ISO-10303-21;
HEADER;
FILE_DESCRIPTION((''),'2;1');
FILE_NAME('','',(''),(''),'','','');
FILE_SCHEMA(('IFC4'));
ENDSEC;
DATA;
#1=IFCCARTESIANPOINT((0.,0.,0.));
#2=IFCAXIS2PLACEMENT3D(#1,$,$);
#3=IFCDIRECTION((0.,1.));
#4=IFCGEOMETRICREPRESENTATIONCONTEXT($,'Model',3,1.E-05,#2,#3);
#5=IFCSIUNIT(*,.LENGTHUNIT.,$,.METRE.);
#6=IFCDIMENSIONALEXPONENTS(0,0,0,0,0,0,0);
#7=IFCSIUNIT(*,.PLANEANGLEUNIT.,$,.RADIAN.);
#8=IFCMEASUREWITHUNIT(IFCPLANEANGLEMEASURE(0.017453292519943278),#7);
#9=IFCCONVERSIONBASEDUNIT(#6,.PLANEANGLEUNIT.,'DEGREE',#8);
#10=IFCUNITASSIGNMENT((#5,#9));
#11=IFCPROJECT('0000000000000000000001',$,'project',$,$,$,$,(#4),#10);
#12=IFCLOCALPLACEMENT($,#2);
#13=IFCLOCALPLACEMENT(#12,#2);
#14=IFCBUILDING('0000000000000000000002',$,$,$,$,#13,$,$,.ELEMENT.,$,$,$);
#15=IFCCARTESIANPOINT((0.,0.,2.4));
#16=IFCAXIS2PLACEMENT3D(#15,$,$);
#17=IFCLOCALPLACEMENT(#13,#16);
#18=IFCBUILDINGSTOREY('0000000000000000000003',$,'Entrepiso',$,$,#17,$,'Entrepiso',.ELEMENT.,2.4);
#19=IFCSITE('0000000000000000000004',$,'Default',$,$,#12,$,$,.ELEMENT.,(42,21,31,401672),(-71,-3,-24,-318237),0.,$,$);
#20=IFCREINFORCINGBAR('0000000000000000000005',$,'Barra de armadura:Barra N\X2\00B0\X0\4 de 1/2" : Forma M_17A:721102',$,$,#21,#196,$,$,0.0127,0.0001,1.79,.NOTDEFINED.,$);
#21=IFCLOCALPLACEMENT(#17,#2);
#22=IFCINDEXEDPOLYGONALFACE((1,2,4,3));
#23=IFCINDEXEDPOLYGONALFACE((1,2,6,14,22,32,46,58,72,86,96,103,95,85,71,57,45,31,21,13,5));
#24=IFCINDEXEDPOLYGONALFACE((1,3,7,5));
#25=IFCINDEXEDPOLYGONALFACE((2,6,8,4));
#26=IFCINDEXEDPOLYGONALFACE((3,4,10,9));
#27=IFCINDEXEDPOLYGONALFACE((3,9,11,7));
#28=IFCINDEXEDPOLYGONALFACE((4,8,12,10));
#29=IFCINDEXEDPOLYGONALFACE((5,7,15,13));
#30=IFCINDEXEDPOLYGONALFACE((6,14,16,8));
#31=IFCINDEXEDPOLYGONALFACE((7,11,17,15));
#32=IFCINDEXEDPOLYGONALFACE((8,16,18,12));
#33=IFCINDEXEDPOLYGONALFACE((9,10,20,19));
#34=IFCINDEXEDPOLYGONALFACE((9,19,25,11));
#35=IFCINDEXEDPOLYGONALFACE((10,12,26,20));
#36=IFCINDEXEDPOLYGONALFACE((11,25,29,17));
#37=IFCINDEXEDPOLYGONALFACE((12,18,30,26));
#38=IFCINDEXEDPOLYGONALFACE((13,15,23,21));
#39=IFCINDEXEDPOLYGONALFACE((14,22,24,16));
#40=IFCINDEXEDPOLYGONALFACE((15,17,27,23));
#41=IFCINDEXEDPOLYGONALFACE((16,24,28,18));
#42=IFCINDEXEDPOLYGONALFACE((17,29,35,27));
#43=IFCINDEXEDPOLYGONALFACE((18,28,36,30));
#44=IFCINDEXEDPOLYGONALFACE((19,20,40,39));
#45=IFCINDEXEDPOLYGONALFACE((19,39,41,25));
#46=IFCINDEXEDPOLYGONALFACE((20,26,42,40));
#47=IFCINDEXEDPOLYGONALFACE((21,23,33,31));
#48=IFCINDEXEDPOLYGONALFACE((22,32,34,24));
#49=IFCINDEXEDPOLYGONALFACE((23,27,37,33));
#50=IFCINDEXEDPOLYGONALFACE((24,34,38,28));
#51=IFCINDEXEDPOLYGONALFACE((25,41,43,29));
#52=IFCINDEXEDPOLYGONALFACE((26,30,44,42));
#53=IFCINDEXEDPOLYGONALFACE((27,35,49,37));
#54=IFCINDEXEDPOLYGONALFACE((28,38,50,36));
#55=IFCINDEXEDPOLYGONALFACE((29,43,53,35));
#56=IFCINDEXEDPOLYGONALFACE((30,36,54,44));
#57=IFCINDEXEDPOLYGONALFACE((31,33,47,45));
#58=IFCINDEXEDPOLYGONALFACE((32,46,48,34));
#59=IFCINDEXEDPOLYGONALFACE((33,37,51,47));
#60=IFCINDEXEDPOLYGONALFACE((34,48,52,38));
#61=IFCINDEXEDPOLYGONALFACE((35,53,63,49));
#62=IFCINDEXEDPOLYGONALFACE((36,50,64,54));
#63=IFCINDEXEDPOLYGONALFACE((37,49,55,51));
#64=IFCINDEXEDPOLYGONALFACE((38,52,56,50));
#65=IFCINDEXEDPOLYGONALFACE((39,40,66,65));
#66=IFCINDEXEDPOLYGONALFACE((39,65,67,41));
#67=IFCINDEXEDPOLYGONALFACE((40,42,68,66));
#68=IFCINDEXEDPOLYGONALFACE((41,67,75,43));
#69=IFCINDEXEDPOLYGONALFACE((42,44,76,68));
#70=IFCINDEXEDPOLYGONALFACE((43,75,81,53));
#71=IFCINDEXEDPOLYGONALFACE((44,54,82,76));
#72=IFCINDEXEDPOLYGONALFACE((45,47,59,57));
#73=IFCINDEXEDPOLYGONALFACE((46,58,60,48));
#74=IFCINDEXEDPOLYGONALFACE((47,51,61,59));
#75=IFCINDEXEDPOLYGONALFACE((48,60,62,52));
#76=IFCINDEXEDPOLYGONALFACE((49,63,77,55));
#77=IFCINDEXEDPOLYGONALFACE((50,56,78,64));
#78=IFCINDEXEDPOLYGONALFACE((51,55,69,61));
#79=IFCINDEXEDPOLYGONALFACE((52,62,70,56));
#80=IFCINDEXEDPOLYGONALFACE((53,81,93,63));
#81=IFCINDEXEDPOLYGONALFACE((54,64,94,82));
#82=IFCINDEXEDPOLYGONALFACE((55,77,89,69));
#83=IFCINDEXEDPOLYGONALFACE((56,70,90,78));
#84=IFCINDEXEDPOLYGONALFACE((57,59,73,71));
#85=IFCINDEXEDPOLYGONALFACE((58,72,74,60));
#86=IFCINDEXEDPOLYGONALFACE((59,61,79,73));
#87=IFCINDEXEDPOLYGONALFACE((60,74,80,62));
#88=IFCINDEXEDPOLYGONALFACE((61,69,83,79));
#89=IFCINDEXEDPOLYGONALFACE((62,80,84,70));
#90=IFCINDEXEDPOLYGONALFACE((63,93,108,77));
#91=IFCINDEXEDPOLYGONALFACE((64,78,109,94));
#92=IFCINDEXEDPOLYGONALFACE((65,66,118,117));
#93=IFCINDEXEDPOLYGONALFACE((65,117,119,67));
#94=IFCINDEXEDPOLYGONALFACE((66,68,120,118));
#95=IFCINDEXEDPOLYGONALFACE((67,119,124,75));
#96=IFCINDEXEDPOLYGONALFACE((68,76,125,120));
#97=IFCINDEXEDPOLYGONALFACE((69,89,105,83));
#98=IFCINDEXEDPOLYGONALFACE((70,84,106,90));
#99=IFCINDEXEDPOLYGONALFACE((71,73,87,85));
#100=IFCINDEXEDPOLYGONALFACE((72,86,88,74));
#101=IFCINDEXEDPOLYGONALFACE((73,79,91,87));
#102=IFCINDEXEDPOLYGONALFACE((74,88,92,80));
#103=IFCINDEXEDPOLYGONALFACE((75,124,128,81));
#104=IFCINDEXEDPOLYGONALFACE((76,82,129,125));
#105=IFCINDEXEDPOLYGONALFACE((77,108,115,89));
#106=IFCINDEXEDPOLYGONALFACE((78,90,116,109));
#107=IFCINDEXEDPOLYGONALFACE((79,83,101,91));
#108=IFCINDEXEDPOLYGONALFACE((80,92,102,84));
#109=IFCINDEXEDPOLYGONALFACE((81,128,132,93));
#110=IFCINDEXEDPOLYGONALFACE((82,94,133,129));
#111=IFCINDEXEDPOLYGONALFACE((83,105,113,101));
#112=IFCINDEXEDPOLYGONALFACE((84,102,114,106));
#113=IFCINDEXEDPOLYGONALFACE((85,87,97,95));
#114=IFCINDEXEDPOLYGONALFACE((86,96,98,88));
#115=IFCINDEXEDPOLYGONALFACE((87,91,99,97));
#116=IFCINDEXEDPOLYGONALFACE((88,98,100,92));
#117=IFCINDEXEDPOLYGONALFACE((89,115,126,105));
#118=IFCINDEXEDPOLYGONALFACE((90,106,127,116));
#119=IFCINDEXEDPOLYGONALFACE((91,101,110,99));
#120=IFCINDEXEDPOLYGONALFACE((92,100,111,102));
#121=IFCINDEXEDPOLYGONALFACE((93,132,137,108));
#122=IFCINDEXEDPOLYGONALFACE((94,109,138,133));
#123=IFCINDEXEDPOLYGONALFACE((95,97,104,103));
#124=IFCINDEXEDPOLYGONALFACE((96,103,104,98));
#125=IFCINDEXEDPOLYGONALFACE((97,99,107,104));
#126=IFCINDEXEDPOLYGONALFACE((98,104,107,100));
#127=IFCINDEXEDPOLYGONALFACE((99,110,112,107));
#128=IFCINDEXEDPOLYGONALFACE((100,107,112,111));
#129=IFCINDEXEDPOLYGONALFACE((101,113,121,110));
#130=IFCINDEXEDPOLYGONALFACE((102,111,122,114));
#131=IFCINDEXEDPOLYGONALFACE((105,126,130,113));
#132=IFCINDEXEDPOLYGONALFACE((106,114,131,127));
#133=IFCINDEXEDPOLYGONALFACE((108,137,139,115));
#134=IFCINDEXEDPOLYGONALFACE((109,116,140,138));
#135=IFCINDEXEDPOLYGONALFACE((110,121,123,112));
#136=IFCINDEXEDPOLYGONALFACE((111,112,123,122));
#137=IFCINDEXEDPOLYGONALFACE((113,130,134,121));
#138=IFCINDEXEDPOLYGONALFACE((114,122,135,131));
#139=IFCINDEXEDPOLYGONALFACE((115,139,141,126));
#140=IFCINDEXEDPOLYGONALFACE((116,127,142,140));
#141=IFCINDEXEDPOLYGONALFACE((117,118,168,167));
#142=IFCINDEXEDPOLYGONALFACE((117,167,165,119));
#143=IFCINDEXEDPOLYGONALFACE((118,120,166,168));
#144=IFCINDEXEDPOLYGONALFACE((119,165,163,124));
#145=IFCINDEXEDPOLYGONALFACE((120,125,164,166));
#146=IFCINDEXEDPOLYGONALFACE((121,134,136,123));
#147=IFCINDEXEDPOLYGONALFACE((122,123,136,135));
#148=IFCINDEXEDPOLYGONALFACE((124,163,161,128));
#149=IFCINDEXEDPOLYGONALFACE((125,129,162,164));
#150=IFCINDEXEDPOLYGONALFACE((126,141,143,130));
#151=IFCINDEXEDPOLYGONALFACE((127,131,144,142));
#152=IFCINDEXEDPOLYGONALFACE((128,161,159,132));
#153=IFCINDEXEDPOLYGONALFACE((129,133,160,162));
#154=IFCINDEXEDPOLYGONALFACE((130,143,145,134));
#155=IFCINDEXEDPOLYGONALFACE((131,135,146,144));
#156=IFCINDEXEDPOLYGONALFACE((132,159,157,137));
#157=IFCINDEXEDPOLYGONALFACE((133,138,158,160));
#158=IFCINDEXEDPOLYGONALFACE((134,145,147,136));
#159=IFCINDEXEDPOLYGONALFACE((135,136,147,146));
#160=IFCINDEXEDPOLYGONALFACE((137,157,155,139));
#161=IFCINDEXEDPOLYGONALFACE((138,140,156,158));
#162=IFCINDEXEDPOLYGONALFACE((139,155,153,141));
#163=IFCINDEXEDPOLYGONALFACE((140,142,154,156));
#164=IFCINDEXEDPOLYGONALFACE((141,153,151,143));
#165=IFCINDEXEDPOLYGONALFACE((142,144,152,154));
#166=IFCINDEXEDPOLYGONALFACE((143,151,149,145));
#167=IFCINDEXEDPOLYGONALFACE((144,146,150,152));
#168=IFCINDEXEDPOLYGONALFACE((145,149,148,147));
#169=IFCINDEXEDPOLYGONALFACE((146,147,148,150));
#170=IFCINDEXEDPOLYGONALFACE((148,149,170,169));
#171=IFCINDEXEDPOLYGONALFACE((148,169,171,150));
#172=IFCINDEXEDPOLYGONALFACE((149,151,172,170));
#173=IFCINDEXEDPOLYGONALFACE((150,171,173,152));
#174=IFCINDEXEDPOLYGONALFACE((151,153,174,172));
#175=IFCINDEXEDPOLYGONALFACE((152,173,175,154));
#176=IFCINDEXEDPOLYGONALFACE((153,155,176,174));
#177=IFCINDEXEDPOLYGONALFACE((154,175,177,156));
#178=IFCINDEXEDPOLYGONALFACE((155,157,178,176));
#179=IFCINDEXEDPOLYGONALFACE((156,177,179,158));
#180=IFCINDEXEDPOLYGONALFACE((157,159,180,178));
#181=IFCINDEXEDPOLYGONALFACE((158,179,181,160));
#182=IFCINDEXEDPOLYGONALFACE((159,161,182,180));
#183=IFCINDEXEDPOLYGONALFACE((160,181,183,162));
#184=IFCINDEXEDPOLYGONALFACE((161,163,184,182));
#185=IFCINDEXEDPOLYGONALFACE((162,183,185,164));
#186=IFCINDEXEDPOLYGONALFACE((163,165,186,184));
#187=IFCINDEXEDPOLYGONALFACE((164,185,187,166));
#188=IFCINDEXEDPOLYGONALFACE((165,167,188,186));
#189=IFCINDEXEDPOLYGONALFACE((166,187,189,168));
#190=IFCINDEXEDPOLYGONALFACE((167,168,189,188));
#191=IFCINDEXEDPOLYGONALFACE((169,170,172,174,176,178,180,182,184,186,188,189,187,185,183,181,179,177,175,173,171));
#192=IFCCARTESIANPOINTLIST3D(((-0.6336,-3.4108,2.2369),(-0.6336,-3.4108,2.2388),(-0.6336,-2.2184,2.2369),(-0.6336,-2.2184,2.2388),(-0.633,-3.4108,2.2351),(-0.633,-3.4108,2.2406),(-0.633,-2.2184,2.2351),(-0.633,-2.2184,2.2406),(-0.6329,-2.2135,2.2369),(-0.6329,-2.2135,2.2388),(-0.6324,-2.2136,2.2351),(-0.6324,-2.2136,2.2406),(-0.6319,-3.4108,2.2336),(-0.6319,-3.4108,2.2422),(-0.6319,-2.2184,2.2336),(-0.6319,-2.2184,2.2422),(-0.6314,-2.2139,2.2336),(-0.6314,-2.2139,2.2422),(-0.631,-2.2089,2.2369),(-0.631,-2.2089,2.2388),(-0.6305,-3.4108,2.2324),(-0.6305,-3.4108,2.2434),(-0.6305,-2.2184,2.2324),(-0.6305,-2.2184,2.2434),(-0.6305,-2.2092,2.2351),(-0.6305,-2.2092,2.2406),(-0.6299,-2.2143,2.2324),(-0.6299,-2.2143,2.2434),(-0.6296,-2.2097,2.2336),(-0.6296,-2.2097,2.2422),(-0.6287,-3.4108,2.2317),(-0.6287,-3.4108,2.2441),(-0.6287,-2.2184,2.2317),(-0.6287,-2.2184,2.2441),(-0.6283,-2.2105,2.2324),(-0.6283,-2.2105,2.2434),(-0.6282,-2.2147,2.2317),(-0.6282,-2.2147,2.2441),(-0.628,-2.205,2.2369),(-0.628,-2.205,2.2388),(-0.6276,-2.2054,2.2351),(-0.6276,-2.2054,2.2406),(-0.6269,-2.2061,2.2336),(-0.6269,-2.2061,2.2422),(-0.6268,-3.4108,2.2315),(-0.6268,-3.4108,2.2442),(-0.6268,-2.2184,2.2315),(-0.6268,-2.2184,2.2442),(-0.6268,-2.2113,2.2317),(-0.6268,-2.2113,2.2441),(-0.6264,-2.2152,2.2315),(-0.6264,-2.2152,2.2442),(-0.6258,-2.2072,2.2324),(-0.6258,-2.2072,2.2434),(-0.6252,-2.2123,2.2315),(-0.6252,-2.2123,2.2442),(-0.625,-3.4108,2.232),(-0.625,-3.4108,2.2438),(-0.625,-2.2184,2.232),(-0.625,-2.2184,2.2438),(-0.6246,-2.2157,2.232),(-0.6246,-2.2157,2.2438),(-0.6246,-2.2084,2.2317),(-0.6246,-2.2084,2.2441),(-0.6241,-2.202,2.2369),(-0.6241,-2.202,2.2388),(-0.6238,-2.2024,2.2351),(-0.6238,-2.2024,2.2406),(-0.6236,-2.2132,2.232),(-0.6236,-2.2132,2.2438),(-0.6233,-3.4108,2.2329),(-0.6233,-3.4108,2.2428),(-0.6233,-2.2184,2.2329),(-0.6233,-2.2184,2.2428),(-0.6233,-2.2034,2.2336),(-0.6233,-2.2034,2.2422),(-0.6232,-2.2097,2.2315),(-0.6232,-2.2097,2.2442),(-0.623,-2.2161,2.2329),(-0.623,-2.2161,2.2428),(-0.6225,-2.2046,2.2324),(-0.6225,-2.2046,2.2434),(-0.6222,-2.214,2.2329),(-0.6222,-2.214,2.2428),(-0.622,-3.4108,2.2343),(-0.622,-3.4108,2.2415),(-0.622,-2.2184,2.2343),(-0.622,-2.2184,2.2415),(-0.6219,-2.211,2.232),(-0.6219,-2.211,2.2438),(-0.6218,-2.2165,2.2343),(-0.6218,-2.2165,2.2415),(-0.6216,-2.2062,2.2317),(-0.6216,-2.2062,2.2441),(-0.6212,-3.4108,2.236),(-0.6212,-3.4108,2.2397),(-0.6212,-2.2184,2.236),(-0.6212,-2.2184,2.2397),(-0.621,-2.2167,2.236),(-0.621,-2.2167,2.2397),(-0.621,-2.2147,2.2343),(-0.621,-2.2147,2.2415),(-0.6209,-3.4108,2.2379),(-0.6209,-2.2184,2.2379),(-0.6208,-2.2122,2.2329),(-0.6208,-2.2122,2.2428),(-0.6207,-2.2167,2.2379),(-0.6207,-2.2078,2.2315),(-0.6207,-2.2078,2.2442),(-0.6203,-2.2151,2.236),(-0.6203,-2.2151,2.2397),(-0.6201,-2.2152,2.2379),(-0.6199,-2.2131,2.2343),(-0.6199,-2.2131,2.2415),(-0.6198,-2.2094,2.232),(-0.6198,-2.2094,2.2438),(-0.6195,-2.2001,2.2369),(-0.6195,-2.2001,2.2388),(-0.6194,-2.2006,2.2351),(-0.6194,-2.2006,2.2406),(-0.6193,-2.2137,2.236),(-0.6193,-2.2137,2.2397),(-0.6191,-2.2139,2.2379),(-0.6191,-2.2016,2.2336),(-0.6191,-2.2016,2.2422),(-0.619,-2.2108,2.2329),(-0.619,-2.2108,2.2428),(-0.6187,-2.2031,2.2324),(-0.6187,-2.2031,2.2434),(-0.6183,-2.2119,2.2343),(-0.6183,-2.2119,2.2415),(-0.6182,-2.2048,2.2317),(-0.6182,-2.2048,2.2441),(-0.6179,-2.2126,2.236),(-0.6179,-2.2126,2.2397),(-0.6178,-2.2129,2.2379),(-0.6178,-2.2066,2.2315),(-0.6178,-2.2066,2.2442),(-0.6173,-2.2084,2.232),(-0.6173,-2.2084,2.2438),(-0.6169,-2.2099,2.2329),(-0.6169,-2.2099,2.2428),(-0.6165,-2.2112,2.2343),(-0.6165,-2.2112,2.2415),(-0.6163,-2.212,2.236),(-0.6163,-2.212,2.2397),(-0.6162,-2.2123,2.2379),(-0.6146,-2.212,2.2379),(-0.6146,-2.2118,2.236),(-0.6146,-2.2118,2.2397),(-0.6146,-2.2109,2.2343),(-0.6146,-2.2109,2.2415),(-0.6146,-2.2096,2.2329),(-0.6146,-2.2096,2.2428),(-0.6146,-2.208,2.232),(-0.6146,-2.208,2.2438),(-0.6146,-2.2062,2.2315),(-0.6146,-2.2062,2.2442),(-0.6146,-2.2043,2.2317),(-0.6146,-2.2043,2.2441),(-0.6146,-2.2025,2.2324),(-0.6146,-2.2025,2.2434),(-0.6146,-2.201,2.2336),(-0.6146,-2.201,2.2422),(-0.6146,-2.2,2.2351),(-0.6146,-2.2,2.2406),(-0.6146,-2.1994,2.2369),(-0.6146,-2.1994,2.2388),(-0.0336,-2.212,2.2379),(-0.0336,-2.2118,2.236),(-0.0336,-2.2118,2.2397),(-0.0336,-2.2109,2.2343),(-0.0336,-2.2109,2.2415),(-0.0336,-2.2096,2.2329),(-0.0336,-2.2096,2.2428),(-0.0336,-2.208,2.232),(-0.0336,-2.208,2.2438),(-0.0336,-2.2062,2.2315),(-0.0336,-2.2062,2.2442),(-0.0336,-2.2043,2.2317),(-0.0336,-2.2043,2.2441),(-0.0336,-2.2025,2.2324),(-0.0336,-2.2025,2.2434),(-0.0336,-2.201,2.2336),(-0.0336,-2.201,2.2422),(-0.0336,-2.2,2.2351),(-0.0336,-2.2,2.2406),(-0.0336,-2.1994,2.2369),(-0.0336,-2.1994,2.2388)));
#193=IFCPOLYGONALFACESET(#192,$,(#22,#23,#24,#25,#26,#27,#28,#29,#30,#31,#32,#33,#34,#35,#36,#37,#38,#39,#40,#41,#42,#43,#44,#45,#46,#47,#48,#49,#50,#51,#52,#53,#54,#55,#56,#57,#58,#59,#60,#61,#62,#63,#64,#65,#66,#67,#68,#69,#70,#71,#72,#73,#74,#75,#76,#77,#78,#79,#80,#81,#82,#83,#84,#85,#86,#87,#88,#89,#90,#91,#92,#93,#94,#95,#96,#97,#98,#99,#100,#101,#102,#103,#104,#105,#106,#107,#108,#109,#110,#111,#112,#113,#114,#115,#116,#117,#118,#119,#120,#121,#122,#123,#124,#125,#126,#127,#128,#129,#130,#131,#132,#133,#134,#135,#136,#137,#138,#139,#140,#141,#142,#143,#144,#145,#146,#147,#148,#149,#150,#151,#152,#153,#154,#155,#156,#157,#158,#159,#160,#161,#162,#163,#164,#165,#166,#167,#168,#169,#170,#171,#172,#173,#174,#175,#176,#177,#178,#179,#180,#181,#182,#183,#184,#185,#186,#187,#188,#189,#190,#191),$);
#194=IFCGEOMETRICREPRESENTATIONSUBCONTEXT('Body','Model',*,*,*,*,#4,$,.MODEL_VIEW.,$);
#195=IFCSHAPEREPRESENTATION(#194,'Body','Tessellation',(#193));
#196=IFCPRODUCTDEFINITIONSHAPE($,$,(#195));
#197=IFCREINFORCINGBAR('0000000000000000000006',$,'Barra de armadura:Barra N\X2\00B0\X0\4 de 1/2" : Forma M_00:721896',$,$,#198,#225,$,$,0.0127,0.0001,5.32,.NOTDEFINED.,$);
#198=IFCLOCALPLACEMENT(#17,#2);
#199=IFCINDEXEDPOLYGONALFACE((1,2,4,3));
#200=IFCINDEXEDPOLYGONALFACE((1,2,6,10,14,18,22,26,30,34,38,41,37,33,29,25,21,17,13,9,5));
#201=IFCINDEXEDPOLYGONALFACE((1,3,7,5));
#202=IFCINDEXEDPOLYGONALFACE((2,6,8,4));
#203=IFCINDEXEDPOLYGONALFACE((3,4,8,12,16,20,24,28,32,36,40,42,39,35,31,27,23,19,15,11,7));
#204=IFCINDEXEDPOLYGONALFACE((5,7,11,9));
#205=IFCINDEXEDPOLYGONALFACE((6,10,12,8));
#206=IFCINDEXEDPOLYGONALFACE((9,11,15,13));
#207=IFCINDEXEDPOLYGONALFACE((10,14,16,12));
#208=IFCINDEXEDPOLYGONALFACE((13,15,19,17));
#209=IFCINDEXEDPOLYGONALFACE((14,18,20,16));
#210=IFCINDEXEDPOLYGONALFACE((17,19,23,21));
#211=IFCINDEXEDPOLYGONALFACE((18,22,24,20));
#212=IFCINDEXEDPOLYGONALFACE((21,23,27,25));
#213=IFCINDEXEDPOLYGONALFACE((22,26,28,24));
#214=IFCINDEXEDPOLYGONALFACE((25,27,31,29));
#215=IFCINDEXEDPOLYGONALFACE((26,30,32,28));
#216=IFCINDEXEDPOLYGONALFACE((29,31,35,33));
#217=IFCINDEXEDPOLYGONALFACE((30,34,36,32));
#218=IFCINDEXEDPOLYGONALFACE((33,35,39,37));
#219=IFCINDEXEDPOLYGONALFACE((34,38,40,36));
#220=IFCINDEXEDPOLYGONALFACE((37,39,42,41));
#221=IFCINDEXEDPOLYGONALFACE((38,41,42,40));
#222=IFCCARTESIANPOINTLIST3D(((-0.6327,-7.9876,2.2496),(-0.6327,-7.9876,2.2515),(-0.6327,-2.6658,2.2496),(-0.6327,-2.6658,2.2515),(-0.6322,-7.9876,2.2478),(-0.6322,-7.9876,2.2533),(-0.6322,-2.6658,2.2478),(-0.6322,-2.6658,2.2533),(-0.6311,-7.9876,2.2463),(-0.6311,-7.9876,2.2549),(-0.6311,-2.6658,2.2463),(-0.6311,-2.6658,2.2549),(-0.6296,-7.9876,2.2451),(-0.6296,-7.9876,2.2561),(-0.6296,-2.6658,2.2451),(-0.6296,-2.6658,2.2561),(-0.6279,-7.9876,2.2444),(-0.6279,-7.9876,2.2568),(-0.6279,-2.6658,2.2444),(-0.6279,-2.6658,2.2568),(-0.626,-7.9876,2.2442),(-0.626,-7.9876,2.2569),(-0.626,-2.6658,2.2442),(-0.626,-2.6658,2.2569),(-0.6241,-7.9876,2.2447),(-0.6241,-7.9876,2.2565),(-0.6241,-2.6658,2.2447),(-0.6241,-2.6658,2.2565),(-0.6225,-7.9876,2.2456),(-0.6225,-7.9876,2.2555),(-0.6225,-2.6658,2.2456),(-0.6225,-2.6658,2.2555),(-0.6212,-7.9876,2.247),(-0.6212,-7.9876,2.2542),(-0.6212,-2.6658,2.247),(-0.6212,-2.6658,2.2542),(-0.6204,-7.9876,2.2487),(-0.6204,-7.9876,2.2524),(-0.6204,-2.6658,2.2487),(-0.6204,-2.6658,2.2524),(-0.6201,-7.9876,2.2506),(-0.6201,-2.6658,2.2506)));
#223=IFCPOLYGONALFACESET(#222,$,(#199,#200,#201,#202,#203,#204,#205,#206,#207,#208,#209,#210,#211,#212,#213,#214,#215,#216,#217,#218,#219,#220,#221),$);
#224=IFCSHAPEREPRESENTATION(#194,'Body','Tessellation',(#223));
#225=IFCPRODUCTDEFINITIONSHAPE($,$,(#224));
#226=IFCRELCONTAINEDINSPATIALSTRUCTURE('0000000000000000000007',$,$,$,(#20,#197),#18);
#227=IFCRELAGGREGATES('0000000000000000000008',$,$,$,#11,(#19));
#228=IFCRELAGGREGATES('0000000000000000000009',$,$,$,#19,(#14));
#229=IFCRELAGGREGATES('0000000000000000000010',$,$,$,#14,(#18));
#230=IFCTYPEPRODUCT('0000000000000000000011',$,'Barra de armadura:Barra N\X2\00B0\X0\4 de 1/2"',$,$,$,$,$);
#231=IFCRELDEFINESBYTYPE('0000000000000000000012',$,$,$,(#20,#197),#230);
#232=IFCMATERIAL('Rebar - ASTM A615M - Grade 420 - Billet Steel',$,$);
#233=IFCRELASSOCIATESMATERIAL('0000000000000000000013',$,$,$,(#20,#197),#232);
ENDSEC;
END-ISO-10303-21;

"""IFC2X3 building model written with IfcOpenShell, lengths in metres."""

from ifc_helpers import new_model, entity, si_unit, converted_unit, direction, frame, origin, place, context, subcontext, project, spatial, material, type_object, element, save


model = new_model("IFC2X3")

# Units and contexts
model_context = context("Model", 3, precision=1e-05, world=origin(), true_north=direction((0.0, 1.0)))
body_context = subcontext(model_context, "Body", "Model", "MODEL_VIEW")
ifc_project = project(units=[si_unit("LENGTHUNIT", "METRE"), converted_unit("PLANEANGLEUNIT", "DEGREE", entity("IfcPlaneAngleMeasure", 0.017453292519943278), si_unit("PLANEANGLEUNIT", "RADIAN"), dimensions=[0, 0, 0, 0, 0, 0, 0])], contexts=[model_context])

# Site, building, storey
site_placement = place(None, origin())
site = spatial("IfcSite", under=ifc_project, at=site_placement, Name="Default", CompositionType="ELEMENT", RefLatitude=(42, 21, 31, 401672), RefLongitude=(-71, -3, -24, -318237), RefElevation=0.0)
building_placement = place(site_placement, origin())
building = spatial("IfcBuilding", under=site, at=building_placement, CompositionType="ELEMENT")
storey_placement = place(building_placement, frame((0.0, 0.0, 2.4)))
storey = spatial("IfcBuildingStorey", under=building, at=storey_placement, Name="Entrepiso", LongName="Entrepiso", CompositionType="ELEMENT", Elevation=2.4)

# Reinforcing bars
ifc_material = material(Name="Rebar - ASTM A615M - Grade 420 - Billet Steel")
type_product_1 = type_object("IfcTypeProduct", Name="Barra de armadura:Barra N°4 de 1/2\"")
reinforcing_bar_1_placement = place(storey_placement, origin())
element("IfcReinforcingBar", 1, at=reinforcing_bar_1_placement, inside=storey, type_object=type_product_1, material=ifc_material, Name="Barra de armadura:Barra N°4 de 1/2\" : Forma M_17A:721102", BarLength=1.79, BarRole="NOTDEFINED", CrossSectionArea=0.0001, NominalDiameter=0.0127, context=body_context, shape_type="AdvancedSweptSolid", body=[
    entity("IfcSweptDiskSolid", entity("IfcCompositeCurve", [entity("IfcCompositeCurveSegment", "CONTINUOUS", True, entity("IfcPolyline", [entity("IfcCartesianPoint", [-0.6273, -3.4108, 2.2379]), entity("IfcCartesianPoint", [-0.6273, -2.2184, 2.2379])])), entity("IfcCompositeCurveSegment", "CONTINUOUS", True, entity("IfcTrimmedCurve", entity("IfcCircle", entity("IfcAxis2Placement3D", entity("IfcCartesianPoint", [-0.6146, -2.2184, 2.2379]), entity("IfcDirection", [0.0, 0.0, -1.0]), entity("IfcDirection", [0.0, 1.0, 0.0])), 0.0127), [entity("IfcParameterValue", 270.0)], [entity("IfcParameterValue", 360.0)], True, "PARAMETER")), entity("IfcCompositeCurveSegment", "CONTINUOUS", True, entity("IfcPolyline", [entity("IfcCartesianPoint", [-0.6146, -2.2057, 2.2379]), entity("IfcCartesianPoint", [-0.0336, -2.2057, 2.2379])]))], False), 0.0063, None, 0.0, 92.0),
])
reinforcing_bar_2_placement = place(storey_placement, origin())
element("IfcReinforcingBar", 2, at=reinforcing_bar_2_placement, inside=storey, type_object=type_product_1, material=ifc_material, Name="Barra de armadura:Barra N°4 de 1/2\" : Forma M_00:721896", BarLength=5.32, BarRole="NOTDEFINED", CrossSectionArea=0.0001, NominalDiameter=0.0127, context=body_context, shape_type="AdvancedSweptSolid", body=[
    entity("IfcSweptDiskSolid", entity("IfcCompositeCurve", [entity("IfcCompositeCurveSegment", "CONTINUOUS", True, entity("IfcPolyline", [entity("IfcCartesianPoint", [-0.6264, -7.9876, 2.2506]), entity("IfcCartesianPoint", [-0.6264, -2.6658, 2.2506])]))], False), 0.0063, None, 0.0, 1.0),
])

save(model, "model.ifc")
